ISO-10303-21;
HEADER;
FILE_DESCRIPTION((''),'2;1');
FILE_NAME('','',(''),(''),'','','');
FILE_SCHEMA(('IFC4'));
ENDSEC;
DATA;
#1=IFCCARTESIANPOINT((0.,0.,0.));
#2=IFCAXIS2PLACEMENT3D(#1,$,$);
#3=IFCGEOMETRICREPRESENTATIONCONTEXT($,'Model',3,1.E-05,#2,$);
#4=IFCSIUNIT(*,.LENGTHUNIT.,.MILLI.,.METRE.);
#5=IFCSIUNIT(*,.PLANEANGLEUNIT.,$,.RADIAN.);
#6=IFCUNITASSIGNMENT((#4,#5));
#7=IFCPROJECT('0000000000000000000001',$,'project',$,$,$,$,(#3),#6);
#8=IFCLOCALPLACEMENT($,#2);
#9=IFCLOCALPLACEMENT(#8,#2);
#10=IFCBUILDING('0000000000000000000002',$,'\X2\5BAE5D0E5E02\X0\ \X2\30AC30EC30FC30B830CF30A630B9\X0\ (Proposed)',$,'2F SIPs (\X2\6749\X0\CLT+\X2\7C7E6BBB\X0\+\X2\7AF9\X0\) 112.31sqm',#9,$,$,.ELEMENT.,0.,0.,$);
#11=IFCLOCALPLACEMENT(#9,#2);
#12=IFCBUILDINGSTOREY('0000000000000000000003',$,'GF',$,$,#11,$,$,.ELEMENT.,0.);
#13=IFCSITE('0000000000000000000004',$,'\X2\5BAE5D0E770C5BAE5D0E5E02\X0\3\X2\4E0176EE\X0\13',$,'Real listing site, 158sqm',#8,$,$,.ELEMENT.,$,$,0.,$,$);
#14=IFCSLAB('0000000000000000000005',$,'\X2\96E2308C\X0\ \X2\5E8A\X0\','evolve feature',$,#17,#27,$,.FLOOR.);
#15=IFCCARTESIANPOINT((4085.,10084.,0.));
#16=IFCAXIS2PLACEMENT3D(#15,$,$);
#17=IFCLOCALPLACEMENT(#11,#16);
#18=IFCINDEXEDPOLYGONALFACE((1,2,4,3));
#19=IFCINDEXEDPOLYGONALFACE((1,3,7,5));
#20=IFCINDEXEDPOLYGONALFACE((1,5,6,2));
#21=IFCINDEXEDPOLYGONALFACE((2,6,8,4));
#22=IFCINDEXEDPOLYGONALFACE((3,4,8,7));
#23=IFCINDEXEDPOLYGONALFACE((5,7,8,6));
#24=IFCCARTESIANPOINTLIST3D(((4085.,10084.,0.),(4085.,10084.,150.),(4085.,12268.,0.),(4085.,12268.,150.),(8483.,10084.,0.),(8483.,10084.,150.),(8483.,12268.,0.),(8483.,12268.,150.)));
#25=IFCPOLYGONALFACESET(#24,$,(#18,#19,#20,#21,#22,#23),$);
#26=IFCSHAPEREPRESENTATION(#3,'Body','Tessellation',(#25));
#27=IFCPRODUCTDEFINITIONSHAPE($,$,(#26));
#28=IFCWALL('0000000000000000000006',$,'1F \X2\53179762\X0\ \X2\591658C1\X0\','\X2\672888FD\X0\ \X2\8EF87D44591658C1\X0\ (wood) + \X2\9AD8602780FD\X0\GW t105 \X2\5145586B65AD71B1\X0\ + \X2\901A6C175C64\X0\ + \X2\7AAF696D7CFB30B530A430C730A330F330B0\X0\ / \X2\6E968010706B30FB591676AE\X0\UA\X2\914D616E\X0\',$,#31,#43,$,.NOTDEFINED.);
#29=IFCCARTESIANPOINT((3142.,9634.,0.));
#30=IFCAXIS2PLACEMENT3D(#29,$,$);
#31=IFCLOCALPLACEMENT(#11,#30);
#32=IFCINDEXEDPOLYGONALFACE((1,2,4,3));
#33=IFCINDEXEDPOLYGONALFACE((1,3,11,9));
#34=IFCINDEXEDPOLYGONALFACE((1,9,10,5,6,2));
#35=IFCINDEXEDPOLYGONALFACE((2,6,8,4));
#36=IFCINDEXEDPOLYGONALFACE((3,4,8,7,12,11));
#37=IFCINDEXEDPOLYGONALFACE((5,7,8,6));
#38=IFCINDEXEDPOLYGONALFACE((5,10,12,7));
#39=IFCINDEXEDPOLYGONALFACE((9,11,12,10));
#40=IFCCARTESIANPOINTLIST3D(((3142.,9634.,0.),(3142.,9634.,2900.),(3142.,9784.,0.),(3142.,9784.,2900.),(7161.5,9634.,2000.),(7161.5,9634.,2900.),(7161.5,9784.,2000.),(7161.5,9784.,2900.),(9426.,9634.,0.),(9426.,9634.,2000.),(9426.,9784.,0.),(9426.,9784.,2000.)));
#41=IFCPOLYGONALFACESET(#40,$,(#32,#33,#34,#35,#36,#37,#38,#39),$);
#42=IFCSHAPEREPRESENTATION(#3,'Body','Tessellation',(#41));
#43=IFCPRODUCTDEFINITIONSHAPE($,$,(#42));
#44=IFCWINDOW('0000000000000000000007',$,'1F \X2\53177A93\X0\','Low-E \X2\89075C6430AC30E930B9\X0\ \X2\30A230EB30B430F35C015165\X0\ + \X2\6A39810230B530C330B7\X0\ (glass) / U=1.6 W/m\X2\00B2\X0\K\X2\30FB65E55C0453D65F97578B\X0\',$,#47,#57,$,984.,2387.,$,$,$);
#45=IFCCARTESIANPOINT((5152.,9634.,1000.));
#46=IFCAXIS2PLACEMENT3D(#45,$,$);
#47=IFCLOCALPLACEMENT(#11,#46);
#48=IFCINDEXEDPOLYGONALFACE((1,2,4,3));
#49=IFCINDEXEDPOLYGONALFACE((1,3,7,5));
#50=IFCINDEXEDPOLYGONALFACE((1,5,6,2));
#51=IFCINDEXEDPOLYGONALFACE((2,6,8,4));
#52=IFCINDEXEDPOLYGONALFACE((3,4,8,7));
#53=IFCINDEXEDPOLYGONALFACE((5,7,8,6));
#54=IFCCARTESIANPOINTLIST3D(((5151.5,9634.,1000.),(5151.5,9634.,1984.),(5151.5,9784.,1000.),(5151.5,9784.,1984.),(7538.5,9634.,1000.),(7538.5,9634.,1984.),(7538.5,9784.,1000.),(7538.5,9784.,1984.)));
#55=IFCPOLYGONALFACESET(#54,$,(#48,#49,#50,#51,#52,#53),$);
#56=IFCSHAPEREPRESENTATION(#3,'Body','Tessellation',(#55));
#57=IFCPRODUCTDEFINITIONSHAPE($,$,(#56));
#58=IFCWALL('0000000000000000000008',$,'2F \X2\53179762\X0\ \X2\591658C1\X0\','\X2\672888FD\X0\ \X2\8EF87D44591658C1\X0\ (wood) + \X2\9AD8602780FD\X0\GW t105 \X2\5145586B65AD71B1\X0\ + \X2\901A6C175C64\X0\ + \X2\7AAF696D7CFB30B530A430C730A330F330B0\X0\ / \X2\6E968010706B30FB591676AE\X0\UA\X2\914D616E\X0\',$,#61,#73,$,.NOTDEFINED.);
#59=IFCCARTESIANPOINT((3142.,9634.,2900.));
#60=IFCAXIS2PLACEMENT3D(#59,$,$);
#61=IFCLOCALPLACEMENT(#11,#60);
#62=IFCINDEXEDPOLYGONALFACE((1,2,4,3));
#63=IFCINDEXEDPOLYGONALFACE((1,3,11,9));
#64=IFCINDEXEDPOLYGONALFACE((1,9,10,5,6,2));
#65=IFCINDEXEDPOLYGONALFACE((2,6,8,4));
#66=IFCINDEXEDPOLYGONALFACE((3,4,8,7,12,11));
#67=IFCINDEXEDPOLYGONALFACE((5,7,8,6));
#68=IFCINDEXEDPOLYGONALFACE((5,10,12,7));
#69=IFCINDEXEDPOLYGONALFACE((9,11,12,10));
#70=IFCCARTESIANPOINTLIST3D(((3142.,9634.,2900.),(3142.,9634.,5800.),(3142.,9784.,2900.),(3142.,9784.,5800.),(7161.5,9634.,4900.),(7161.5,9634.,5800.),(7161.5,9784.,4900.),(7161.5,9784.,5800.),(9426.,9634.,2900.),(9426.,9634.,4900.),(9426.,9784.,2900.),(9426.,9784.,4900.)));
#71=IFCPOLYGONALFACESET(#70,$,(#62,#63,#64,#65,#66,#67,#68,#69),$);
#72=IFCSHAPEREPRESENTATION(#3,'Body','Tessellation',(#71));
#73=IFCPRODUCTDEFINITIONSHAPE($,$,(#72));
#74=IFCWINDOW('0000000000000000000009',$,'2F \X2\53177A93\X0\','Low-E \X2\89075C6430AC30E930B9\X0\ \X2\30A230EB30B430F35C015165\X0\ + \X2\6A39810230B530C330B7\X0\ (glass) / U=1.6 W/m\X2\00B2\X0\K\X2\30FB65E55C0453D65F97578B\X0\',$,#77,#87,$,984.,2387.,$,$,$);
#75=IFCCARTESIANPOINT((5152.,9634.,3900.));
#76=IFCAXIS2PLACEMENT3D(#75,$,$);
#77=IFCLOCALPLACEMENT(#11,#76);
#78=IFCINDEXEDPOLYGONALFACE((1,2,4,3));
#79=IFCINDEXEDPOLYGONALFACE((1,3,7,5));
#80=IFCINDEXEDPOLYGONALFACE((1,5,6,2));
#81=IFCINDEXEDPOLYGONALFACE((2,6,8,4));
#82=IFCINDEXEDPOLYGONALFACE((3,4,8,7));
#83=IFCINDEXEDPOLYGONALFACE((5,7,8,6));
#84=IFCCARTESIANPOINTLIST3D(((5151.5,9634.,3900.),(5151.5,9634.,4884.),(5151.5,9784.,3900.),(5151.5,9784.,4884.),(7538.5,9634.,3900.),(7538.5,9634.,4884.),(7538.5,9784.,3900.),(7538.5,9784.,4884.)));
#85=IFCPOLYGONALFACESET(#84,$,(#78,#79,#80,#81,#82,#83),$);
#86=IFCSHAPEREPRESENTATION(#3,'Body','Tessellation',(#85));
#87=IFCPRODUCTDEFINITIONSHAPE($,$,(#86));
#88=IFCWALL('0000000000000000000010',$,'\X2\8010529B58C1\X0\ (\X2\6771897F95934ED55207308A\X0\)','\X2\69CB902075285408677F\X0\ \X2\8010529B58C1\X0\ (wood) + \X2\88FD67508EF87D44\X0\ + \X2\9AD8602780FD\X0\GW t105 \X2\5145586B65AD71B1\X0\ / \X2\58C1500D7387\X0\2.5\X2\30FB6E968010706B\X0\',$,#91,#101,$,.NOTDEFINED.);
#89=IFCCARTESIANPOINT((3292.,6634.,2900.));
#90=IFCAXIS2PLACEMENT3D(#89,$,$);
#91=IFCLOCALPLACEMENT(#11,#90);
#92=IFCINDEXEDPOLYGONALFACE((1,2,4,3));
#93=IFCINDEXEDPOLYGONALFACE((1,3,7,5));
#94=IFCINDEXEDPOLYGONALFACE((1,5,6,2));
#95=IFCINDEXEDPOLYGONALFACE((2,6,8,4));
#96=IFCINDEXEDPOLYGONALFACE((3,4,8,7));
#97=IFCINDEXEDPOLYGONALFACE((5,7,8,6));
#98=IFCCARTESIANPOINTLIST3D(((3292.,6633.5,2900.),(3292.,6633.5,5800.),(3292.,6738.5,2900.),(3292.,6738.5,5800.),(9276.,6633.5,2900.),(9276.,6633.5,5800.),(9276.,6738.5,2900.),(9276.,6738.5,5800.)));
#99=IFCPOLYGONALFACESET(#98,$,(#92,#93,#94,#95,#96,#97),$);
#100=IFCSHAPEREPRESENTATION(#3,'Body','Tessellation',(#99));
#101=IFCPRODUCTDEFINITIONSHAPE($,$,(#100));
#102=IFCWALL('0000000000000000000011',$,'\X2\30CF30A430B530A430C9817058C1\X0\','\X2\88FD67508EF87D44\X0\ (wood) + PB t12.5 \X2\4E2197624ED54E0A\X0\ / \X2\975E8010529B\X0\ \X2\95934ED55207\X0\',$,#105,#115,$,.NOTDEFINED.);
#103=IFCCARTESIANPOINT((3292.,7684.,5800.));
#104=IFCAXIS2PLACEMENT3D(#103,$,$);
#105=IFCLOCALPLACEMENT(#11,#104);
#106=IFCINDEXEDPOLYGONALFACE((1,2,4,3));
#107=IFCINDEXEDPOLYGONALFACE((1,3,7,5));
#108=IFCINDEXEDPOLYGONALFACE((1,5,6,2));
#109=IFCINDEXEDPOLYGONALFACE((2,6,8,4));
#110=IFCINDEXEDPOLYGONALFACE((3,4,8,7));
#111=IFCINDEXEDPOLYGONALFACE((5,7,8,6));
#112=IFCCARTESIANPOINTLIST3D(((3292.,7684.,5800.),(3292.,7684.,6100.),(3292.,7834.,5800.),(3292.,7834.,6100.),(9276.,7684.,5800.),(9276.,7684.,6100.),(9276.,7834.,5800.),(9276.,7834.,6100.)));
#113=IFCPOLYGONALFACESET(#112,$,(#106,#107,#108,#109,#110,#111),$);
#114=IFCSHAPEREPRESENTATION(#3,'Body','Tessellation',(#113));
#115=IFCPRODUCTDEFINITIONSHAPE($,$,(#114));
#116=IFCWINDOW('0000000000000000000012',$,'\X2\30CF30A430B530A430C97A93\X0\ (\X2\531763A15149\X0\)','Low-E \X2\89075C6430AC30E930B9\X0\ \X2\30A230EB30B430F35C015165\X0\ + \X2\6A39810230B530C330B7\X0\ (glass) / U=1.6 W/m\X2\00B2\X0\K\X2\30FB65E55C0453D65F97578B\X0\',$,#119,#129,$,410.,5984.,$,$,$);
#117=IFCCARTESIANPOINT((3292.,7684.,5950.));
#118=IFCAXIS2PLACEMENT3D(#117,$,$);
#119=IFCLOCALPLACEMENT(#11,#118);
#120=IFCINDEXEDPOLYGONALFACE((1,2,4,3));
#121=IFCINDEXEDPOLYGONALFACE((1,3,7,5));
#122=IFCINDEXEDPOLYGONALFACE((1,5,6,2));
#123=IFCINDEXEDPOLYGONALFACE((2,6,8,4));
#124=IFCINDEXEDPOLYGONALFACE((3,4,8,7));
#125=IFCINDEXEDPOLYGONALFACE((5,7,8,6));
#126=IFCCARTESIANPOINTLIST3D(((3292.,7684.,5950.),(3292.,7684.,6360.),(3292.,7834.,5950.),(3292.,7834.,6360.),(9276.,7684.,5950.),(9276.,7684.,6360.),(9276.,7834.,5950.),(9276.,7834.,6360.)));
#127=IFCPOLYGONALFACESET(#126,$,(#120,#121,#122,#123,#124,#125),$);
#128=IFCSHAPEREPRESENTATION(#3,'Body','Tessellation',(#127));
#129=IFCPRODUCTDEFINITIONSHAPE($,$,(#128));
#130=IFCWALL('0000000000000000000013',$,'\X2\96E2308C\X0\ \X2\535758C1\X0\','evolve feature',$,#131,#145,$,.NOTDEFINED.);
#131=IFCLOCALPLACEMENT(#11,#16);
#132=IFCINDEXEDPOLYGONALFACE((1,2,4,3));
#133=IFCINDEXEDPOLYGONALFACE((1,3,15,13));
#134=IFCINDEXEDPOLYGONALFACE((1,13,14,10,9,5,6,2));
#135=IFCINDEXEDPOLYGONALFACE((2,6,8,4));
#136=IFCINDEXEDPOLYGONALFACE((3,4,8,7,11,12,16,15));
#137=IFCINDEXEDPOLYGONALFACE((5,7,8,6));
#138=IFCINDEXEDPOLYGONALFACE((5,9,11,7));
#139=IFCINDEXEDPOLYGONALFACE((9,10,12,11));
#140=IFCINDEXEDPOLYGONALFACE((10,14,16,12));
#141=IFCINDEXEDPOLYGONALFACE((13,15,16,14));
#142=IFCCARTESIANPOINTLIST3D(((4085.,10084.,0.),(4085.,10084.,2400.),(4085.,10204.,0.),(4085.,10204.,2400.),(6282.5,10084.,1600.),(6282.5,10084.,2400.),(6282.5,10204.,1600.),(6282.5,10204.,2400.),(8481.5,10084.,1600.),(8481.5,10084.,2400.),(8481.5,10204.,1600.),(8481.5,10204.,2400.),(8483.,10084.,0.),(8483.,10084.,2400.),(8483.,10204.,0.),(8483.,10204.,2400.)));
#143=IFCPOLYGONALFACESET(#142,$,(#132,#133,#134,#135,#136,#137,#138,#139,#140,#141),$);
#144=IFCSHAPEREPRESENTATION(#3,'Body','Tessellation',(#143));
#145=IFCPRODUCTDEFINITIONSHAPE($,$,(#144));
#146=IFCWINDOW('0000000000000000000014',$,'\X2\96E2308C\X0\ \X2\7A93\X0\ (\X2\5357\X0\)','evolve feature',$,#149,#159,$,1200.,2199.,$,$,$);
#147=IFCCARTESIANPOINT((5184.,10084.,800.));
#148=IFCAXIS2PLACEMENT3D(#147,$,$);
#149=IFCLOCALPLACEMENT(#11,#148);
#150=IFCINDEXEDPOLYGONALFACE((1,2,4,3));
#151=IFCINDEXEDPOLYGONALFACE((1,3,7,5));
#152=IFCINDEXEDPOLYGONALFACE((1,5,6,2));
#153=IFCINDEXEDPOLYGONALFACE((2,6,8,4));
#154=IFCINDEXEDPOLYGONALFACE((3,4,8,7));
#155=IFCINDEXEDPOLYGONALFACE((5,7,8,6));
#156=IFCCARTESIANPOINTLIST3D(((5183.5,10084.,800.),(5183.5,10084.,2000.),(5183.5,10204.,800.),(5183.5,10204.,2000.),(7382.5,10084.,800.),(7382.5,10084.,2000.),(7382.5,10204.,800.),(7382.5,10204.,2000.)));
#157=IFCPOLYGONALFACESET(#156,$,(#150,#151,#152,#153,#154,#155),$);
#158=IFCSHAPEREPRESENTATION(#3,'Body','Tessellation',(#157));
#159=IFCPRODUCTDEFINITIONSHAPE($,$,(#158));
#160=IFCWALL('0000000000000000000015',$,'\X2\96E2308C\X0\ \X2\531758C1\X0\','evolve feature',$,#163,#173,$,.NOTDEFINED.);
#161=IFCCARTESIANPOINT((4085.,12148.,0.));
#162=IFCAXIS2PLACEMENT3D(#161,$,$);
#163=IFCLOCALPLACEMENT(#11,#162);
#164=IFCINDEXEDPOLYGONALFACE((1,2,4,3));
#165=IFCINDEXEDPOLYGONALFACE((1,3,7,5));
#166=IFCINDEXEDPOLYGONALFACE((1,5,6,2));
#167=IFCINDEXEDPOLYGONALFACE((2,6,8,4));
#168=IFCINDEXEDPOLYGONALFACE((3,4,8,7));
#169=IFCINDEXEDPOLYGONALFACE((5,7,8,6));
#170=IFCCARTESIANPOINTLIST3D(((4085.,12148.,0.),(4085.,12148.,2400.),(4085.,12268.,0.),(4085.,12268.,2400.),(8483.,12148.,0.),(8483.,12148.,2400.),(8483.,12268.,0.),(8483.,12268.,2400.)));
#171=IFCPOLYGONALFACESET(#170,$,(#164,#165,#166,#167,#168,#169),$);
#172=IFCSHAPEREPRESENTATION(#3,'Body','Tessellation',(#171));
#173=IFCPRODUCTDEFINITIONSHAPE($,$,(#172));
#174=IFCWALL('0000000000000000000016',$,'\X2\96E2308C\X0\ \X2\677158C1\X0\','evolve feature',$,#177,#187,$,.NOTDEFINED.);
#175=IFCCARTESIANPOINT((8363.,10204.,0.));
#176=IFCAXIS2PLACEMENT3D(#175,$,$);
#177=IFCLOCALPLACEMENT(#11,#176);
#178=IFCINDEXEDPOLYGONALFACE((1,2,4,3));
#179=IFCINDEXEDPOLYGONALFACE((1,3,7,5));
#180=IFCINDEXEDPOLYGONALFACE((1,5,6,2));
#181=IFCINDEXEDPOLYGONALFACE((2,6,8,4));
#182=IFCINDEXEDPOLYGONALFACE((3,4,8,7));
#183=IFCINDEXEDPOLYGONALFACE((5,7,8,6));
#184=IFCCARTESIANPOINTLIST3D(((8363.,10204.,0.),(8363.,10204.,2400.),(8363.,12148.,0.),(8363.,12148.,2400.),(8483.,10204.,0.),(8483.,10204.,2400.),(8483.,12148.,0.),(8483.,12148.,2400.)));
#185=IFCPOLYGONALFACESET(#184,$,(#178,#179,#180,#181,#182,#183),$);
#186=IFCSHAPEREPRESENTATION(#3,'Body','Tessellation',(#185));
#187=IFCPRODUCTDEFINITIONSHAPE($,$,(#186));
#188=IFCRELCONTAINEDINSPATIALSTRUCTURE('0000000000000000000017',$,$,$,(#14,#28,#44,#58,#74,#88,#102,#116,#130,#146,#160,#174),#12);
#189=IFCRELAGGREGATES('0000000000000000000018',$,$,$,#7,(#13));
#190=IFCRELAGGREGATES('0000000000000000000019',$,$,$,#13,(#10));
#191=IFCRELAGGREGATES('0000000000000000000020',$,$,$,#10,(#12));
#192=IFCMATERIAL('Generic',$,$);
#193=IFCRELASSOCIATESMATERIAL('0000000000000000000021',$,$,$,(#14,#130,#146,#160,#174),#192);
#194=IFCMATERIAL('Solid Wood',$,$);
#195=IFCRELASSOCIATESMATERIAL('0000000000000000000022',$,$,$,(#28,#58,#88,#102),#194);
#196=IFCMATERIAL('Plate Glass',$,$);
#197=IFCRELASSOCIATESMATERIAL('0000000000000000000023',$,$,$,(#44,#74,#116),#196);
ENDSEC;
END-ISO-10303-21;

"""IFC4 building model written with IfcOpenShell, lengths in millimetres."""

from ifc_helpers import new_model, si_unit, frame, frame_2d, origin, place, context, project, spatial, rectangle, extrude, material, element, fill, save


model = new_model("IFC4")

# Units and contexts
model_context = context("Model", 3, precision=1e-05, world=origin())
ifc_project = project(units=[si_unit("LENGTHUNIT", "METRE", prefix="MILLI"), si_unit("PLANEANGLEUNIT", "RADIAN")], contexts=[model_context])

# Site, building, storey
site_placement = place(None, origin())
site = spatial("IfcSite", under=ifc_project, at=site_placement, Name="宮崎県宮崎市3丁目13", ObjectType="Real listing site, 158sqm", CompositionType="ELEMENT", RefElevation=0.0)
building_placement = place(site_placement, origin())
building = spatial("IfcBuilding", under=site, at=building_placement, Name="宮崎市 ガレージハウス (Proposed)", ObjectType="2F SIPs (杉CLT+籾殻+竹) 112.31sqm", CompositionType="ELEMENT", ElevationOfRefHeight=0.0, ElevationOfTerrain=0.0)
storey_placement = place(building_placement, origin())
storey = spatial("IfcBuildingStorey", under=building, at=storey_placement, Name="GF", CompositionType="ELEMENT", Elevation=0.0)

# Slab
ifc_material_1 = material(Name="Generic")
slab_placement = place(storey_placement, frame((4085.0, 10084.0, 0.0)))
element("IfcSlab", 1, at=slab_placement, inside=storey, material=ifc_material_1, Name="離れ 床", Description="evolve feature", PredefinedType="FLOOR", context=model_context, shape_type="SweptSolid", body=[
    extrude(rectangle(XDim=4398.0, YDim=2184.0, at=frame_2d((2199.0, 1092.0))), frame((4085.0, 10084.0, 0.0)), (0.0, 0.0, 1.0), 150.0),
])

# Wall, opening, window
ifc_material_2 = material(Name="Solid Wood")
wall_1_placement = place(storey_placement, frame((3142.0, 9634.0, 0.0)))
wall_1 = element("IfcWall", 2, at=wall_1_placement, inside=storey, material=ifc_material_2, Name="1F 北面 外壁", Description="木製 軸組外壁 (wood) + 高性能GW t105 充填断熱 + 通気層 + 窯業系サイディング / 準耐火・外皮UA配慮", PredefinedType="NOTDEFINED", context=model_context, shape_type="SweptSolid", body=[
    extrude(rectangle(XDim=6284.0, YDim=150.0, at=frame_2d((3142.0, 75.0))), frame((3142.0, 9634.0, 0.0)), (0.0, 0.0, 1.0), 2900.0),
])
opening_1_placement = place(storey_placement, frame((5152.0, 9634.0, 1000.0)))
opening_1 = element("IfcOpeningElement", 3, at=opening_1_placement, cuts=wall_1, PredefinedType="NOTDEFINED", context=model_context, shape_type="SweptSolid", body=[
    extrude(rectangle(XDim=2387.0, YDim=150.0, at=frame_2d((1193.0, 75.0))), frame((5152.0, 9634.0, 1000.0)), (0.0, 0.0, 1.0), 984.0),
])
ifc_material_3 = material(Name="Plate Glass")
window_1_placement = place(storey_placement, frame((5152.0, 9634.0, 1000.0)))
window_1 = element("IfcWindow", 4, at=window_1_placement, inside=storey, material=ifc_material_3, Name="1F 北窓", Description="Low-E 複層ガラス アルゴン封入 + 樹脂サッシ (glass) / U=1.6 W/m²K・日射取得型", OverallHeight=984.0, OverallWidth=2387.0, context=model_context, shape_type="SweptSolid", body=[
    extrude(rectangle(XDim=2387.0, YDim=150.0, at=frame_2d((1193.0, 75.0))), frame((5152.0, 9634.0, 1000.0)), (0.0, 0.0, 1.0), 984.0),
])
fill(opening_1, window_1)

# Wall, opening, window
wall_2_placement = place(storey_placement, frame((3142.0, 9634.0, 2900.0)))
wall_2 = element("IfcWall", 5, at=wall_2_placement, inside=storey, material=ifc_material_2, Name="2F 北面 外壁", Description="木製 軸組外壁 (wood) + 高性能GW t105 充填断熱 + 通気層 + 窯業系サイディング / 準耐火・外皮UA配慮", PredefinedType="NOTDEFINED", context=model_context, shape_type="SweptSolid", body=[
    extrude(rectangle(XDim=6284.0, YDim=150.0, at=frame_2d((3142.0, 75.0))), frame((3142.0, 9634.0, 2900.0)), (0.0, 0.0, 1.0), 2900.0),
])
opening_2_placement = place(storey_placement, frame((5152.0, 9634.0, 3900.0)))
opening_2 = element("IfcOpeningElement", 6, at=opening_2_placement, cuts=wall_2, PredefinedType="NOTDEFINED", context=model_context, shape_type="SweptSolid", body=[
    extrude(rectangle(XDim=2387.0, YDim=150.0, at=frame_2d((1193.0, 75.0))), frame((5152.0, 9634.0, 3900.0)), (0.0, 0.0, 1.0), 984.0),
])
window_2_placement = place(storey_placement, frame((5152.0, 9634.0, 3900.0)))
window_2 = element("IfcWindow", 7, at=window_2_placement, inside=storey, material=ifc_material_3, Name="2F 北窓", Description="Low-E 複層ガラス アルゴン封入 + 樹脂サッシ (glass) / U=1.6 W/m²K・日射取得型", OverallHeight=984.0, OverallWidth=2387.0, context=model_context, shape_type="SweptSolid", body=[
    extrude(rectangle(XDim=2387.0, YDim=150.0, at=frame_2d((1193.0, 75.0))), frame((5152.0, 9634.0, 3900.0)), (0.0, 0.0, 1.0), 984.0),
])
fill(opening_2, window_2)

# Wall
wall_3_placement = place(storey_placement, frame((3292.0, 6634.0, 2900.0)))
element("IfcWall", 8, at=wall_3_placement, inside=storey, material=ifc_material_2, Name="耐力壁 (東西間仕切り)", Description="構造用合板 耐力壁 (wood) + 製材軸組 + 高性能GW t105 充填断熱 / 壁倍率2.5・準耐火", PredefinedType="NOTDEFINED", context=model_context, shape_type="SweptSolid", body=[
    extrude(rectangle(XDim=5984.0, YDim=105.0, at=frame_2d((2992.0, 52.0))), frame((3292.0, 6634.0, 2900.0)), (0.0, 0.0, 1.0), 2900.0),
])

# Walls, openings, windows
wall_4_placement = place(storey_placement, frame((3292.0, 7684.0, 5800.0)))
wall_4 = element("IfcWall", 9, at=wall_4_placement, inside=storey, material=ifc_material_2, Name="ハイサイド腰壁", Description="製材軸組 (wood) + PB t12.5 両面仕上 / 非耐力 間仕切", PredefinedType="NOTDEFINED", context=model_context, shape_type="SweptSolid", body=[
    extrude(rectangle(XDim=5984.0, YDim=150.0, at=frame_2d((2992.0, 75.0))), frame((3292.0, 7684.0, 5800.0)), (0.0, 0.0, 1.0), 700.0),
])
opening_3_placement = place(storey_placement, frame((3292.0, 7684.0, 5950.0)))
opening_3 = element("IfcOpeningElement", 10, at=opening_3_placement, cuts=wall_4, PredefinedType="NOTDEFINED", context=model_context, shape_type="SweptSolid", body=[
    extrude(rectangle(XDim=5984.0, YDim=150.0, at=frame_2d((2992.0, 75.0))), frame((3292.0, 7684.0, 5950.0)), (0.0, 0.0, 1.0), 410.0),
])
window_3_placement = place(storey_placement, frame((3292.0, 7684.0, 5950.0)))
window_3 = element("IfcWindow", 11, at=window_3_placement, inside=storey, material=ifc_material_3, Name="ハイサイド窓 (北採光)", Description="Low-E 複層ガラス アルゴン封入 + 樹脂サッシ (glass) / U=1.6 W/m²K・日射取得型", OverallHeight=410.0, OverallWidth=5984.0, context=model_context, shape_type="SweptSolid", body=[
    extrude(rectangle(XDim=5984.0, YDim=150.0, at=frame_2d((2992.0, 75.0))), frame((3292.0, 7684.0, 5950.0)), (0.0, 0.0, 1.0), 410.0),
])
fill(opening_3, window_3)
wall_5_placement = place(storey_placement, frame((4085.0, 10084.0, 0.0)))
wall_5 = element("IfcWall", 12, at=wall_5_placement, inside=storey, material=ifc_material_1, Name="離れ 南壁", Description="evolve feature", PredefinedType="NOTDEFINED", context=model_context, shape_type="SweptSolid", body=[
    extrude(rectangle(XDim=4398.0, YDim=120.0, at=frame_2d((2199.0, 60.0))), frame((4085.0, 10084.0, 0.0)), (0.0, 0.0, 1.0), 2400.0),
])
opening_4_placement = place(storey_placement, frame((5184.0, 10084.0, 800.0)))
opening_4 = element("IfcOpeningElement", 13, at=opening_4_placement, cuts=wall_5, PredefinedType="NOTDEFINED", context=model_context, shape_type="SweptSolid", body=[
    extrude(rectangle(XDim=2199.0, YDim=120.0, at=frame_2d((1099.0, 60.0))), frame((5184.0, 10084.0, 800.0)), (0.0, 0.0, 1.0), 1200.0),
])
window_4_placement = place(storey_placement, frame((5184.0, 10084.0, 800.0)))
window_4 = element("IfcWindow", 14, at=window_4_placement, inside=storey, material=ifc_material_1, Name="離れ 窓 (南)", Description="evolve feature", OverallHeight=1200.0, OverallWidth=2199.0, context=model_context, shape_type="SweptSolid", body=[
    extrude(rectangle(XDim=2199.0, YDim=120.0, at=frame_2d((1099.0, 60.0))), frame((5184.0, 10084.0, 800.0)), (0.0, 0.0, 1.0), 1200.0),
])
fill(opening_4, window_4)

# Walls
wall_6_placement = place(storey_placement, frame((4085.0, 12148.0, 0.0)))
element("IfcWall", 15, at=wall_6_placement, inside=storey, material=ifc_material_1, Name="離れ 北壁", Description="evolve feature", PredefinedType="NOTDEFINED", context=model_context, shape_type="SweptSolid", body=[
    extrude(rectangle(XDim=4398.0, YDim=120.0, at=frame_2d((2199.0, 60.0))), frame((4085.0, 12148.0, 0.0)), (0.0, 0.0, 1.0), 2400.0),
])
wall_7_placement = place(storey_placement, frame((8363.0, 10204.0, 0.0)))
element("IfcWall", 16, at=wall_7_placement, inside=storey, material=ifc_material_1, Name="離れ 東壁", Description="evolve feature", PredefinedType="NOTDEFINED", context=model_context, shape_type="SweptSolid", body=[
    extrude(rectangle(XDim=120.0, YDim=1944.0, at=frame_2d((60.0, 972.0))), frame((8363.0, 10204.0, 0.0)), (0.0, 0.0, 1.0), 2400.0),
])

save(model, "model.ifc")
